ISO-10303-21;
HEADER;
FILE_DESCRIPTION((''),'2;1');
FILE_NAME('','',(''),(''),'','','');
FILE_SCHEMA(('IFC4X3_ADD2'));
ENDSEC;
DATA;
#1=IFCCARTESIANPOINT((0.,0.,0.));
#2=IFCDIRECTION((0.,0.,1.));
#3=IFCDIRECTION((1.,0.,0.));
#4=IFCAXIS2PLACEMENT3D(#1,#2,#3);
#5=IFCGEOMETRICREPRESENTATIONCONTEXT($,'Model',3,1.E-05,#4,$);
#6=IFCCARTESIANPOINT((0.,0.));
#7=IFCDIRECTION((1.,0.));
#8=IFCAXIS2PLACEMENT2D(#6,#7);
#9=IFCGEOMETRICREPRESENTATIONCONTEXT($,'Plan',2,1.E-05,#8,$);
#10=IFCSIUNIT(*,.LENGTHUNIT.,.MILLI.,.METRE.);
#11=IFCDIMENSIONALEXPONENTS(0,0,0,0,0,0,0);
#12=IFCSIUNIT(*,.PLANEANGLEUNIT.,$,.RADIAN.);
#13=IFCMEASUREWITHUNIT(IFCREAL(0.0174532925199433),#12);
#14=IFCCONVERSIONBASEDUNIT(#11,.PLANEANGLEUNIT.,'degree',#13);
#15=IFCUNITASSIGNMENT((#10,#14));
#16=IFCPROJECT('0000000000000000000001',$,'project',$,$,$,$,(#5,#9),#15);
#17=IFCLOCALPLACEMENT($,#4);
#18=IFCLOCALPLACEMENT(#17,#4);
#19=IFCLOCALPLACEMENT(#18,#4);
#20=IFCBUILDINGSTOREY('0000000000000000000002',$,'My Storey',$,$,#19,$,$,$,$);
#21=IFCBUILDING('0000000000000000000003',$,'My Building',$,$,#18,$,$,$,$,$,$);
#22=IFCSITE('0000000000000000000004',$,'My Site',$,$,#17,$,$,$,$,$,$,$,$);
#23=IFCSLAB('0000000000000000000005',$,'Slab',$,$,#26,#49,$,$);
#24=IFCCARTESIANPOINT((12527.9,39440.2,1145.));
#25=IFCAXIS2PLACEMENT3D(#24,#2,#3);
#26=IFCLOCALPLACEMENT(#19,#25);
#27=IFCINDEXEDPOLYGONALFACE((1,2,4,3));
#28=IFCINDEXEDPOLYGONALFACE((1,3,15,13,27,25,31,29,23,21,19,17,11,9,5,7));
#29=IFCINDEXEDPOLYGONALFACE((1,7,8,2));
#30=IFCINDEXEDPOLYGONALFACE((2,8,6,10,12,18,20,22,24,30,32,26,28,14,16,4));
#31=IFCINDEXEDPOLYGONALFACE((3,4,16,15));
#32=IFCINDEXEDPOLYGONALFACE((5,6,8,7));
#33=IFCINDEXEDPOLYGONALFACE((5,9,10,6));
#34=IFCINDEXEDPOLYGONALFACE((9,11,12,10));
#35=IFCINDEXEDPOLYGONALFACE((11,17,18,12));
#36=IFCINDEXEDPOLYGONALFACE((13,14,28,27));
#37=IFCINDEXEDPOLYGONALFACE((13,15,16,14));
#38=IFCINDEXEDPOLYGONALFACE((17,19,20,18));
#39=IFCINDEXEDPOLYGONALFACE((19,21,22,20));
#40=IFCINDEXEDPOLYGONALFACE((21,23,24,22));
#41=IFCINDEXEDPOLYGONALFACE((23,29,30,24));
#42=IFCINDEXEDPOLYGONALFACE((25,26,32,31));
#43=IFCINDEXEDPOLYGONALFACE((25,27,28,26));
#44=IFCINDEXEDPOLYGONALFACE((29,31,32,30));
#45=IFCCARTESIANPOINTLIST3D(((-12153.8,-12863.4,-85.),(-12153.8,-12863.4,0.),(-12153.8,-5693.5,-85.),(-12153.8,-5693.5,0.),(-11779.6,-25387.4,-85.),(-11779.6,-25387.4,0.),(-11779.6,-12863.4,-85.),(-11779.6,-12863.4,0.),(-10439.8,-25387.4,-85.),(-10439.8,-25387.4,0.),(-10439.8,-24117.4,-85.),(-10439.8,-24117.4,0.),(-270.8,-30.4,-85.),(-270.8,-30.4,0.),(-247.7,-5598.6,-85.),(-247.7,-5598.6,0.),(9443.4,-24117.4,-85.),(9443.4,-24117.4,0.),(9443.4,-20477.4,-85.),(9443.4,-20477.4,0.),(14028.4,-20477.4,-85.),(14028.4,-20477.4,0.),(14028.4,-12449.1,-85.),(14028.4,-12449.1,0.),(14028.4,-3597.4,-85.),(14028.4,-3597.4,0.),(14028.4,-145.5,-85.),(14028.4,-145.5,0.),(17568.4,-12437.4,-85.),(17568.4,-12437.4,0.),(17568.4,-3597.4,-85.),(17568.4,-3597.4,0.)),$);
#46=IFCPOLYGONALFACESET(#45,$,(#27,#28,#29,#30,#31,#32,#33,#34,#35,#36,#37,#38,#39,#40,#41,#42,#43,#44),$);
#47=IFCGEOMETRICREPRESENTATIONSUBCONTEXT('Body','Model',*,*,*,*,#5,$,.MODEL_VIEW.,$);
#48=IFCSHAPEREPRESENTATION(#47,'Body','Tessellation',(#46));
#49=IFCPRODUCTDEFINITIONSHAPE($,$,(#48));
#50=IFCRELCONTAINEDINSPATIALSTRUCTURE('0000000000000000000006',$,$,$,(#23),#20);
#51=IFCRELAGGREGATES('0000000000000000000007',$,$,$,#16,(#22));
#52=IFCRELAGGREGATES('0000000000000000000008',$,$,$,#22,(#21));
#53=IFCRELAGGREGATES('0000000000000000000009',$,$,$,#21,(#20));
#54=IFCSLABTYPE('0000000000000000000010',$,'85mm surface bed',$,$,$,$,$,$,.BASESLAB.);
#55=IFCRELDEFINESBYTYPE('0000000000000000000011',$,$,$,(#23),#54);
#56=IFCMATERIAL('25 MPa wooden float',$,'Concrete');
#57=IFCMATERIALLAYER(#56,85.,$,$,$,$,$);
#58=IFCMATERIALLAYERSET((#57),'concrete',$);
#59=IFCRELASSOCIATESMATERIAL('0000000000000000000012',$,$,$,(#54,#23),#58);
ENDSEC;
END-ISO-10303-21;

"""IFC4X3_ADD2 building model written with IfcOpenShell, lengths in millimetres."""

from ifc_helpers import new_model, entity, si_unit, converted_unit, frame, origin_with_axes, origin_2d_with_axis, place, context, subcontext, project, spatial, indexed_curve, outline, extrude, material, layer, layer_set, layer_usage, type_object, element, save


model = new_model("IFC4X3_ADD2")

# Units and contexts
model_context = context("Model", 3, precision=1e-05, world=origin_with_axes())
plan_context = context("Plan", 2, precision=1e-05, world=origin_2d_with_axis())
body_context_1 = subcontext(model_context, "Body", "Model", "MODEL_VIEW")
ifc_project = project(units=[si_unit("LENGTHUNIT", "METRE", prefix="MILLI"), converted_unit("PLANEANGLEUNIT", "degree", entity("IfcReal", 0.0174532925199433), si_unit("PLANEANGLEUNIT", "RADIAN"), dimensions=[0, 0, 0, 0, 0, 0, 0])], contexts=[model_context, plan_context])

# Site, building, storey
site_placement = place(None, origin_with_axes())
site = spatial("IfcSite", under=ifc_project, at=site_placement, Name="My Site")
building_placement = place(site_placement, origin_with_axes())
building = spatial("IfcBuilding", under=site, at=building_placement, Name="My Building")
storey_placement = place(building_placement, origin_with_axes())
storey = spatial("IfcBuildingStorey", under=building, at=storey_placement, Name="My Storey")

# Slab
ifc_material_1 = material(Name="25 MPa wooden float", Category="Concrete")
ifc_layer_1 = layer(ifc_material_1, 85.0)
ifc_layer_set_1 = layer_set([ifc_layer_1], Name="concrete")
ifc_layer_usage_1 = layer_usage(ifc_layer_set_1, "AXIS3", "POSITIVE", -85.0)
slab_type = type_object("IfcSlabType", Name="85mm surface bed", PredefinedType="BASESLAB", material=ifc_layer_set_1)
slab_placement = place(storey_placement, frame((12527.9, 39440.2, 1145.0), z_axis=(0.0, 0.0, 1.0), x_axis=(1.0, 0.0, 0.0)))
element("IfcSlab", 1, at=slab_placement, inside=storey, type_object=slab_type, material=ifc_layer_usage_1, Name="Slab", context=body_context_1, shape_type="SweptSolid", body=[
    extrude(outline(indexed_curve([(9443.4, -24117.4), (-10439.8, -24117.4), (-10439.8, -25387.4), (-11779.6, -25387.4), (-11779.6, -12863.4), (-12153.8, -12863.4), (-12153.8, -5693.5), (-247.7, -5598.6), (-270.8, -30.4), (14028.4, -145.5), (14028.4, -3597.4), (17568.4, -3597.4), (17568.4, -12437.4), (14028.4, -12449.1), (14028.4, -20477.4), (9443.4, -20477.4), (9443.4, -24117.4)])), frame((0.0, 0.0, -85.0), z_axis=(0.0, 0.0, 1.0), x_axis=(1.0, 0.0, 0.0)), (0.0, 0.0, 1.0), 85.0),
])

save(model, "model.ifc")
